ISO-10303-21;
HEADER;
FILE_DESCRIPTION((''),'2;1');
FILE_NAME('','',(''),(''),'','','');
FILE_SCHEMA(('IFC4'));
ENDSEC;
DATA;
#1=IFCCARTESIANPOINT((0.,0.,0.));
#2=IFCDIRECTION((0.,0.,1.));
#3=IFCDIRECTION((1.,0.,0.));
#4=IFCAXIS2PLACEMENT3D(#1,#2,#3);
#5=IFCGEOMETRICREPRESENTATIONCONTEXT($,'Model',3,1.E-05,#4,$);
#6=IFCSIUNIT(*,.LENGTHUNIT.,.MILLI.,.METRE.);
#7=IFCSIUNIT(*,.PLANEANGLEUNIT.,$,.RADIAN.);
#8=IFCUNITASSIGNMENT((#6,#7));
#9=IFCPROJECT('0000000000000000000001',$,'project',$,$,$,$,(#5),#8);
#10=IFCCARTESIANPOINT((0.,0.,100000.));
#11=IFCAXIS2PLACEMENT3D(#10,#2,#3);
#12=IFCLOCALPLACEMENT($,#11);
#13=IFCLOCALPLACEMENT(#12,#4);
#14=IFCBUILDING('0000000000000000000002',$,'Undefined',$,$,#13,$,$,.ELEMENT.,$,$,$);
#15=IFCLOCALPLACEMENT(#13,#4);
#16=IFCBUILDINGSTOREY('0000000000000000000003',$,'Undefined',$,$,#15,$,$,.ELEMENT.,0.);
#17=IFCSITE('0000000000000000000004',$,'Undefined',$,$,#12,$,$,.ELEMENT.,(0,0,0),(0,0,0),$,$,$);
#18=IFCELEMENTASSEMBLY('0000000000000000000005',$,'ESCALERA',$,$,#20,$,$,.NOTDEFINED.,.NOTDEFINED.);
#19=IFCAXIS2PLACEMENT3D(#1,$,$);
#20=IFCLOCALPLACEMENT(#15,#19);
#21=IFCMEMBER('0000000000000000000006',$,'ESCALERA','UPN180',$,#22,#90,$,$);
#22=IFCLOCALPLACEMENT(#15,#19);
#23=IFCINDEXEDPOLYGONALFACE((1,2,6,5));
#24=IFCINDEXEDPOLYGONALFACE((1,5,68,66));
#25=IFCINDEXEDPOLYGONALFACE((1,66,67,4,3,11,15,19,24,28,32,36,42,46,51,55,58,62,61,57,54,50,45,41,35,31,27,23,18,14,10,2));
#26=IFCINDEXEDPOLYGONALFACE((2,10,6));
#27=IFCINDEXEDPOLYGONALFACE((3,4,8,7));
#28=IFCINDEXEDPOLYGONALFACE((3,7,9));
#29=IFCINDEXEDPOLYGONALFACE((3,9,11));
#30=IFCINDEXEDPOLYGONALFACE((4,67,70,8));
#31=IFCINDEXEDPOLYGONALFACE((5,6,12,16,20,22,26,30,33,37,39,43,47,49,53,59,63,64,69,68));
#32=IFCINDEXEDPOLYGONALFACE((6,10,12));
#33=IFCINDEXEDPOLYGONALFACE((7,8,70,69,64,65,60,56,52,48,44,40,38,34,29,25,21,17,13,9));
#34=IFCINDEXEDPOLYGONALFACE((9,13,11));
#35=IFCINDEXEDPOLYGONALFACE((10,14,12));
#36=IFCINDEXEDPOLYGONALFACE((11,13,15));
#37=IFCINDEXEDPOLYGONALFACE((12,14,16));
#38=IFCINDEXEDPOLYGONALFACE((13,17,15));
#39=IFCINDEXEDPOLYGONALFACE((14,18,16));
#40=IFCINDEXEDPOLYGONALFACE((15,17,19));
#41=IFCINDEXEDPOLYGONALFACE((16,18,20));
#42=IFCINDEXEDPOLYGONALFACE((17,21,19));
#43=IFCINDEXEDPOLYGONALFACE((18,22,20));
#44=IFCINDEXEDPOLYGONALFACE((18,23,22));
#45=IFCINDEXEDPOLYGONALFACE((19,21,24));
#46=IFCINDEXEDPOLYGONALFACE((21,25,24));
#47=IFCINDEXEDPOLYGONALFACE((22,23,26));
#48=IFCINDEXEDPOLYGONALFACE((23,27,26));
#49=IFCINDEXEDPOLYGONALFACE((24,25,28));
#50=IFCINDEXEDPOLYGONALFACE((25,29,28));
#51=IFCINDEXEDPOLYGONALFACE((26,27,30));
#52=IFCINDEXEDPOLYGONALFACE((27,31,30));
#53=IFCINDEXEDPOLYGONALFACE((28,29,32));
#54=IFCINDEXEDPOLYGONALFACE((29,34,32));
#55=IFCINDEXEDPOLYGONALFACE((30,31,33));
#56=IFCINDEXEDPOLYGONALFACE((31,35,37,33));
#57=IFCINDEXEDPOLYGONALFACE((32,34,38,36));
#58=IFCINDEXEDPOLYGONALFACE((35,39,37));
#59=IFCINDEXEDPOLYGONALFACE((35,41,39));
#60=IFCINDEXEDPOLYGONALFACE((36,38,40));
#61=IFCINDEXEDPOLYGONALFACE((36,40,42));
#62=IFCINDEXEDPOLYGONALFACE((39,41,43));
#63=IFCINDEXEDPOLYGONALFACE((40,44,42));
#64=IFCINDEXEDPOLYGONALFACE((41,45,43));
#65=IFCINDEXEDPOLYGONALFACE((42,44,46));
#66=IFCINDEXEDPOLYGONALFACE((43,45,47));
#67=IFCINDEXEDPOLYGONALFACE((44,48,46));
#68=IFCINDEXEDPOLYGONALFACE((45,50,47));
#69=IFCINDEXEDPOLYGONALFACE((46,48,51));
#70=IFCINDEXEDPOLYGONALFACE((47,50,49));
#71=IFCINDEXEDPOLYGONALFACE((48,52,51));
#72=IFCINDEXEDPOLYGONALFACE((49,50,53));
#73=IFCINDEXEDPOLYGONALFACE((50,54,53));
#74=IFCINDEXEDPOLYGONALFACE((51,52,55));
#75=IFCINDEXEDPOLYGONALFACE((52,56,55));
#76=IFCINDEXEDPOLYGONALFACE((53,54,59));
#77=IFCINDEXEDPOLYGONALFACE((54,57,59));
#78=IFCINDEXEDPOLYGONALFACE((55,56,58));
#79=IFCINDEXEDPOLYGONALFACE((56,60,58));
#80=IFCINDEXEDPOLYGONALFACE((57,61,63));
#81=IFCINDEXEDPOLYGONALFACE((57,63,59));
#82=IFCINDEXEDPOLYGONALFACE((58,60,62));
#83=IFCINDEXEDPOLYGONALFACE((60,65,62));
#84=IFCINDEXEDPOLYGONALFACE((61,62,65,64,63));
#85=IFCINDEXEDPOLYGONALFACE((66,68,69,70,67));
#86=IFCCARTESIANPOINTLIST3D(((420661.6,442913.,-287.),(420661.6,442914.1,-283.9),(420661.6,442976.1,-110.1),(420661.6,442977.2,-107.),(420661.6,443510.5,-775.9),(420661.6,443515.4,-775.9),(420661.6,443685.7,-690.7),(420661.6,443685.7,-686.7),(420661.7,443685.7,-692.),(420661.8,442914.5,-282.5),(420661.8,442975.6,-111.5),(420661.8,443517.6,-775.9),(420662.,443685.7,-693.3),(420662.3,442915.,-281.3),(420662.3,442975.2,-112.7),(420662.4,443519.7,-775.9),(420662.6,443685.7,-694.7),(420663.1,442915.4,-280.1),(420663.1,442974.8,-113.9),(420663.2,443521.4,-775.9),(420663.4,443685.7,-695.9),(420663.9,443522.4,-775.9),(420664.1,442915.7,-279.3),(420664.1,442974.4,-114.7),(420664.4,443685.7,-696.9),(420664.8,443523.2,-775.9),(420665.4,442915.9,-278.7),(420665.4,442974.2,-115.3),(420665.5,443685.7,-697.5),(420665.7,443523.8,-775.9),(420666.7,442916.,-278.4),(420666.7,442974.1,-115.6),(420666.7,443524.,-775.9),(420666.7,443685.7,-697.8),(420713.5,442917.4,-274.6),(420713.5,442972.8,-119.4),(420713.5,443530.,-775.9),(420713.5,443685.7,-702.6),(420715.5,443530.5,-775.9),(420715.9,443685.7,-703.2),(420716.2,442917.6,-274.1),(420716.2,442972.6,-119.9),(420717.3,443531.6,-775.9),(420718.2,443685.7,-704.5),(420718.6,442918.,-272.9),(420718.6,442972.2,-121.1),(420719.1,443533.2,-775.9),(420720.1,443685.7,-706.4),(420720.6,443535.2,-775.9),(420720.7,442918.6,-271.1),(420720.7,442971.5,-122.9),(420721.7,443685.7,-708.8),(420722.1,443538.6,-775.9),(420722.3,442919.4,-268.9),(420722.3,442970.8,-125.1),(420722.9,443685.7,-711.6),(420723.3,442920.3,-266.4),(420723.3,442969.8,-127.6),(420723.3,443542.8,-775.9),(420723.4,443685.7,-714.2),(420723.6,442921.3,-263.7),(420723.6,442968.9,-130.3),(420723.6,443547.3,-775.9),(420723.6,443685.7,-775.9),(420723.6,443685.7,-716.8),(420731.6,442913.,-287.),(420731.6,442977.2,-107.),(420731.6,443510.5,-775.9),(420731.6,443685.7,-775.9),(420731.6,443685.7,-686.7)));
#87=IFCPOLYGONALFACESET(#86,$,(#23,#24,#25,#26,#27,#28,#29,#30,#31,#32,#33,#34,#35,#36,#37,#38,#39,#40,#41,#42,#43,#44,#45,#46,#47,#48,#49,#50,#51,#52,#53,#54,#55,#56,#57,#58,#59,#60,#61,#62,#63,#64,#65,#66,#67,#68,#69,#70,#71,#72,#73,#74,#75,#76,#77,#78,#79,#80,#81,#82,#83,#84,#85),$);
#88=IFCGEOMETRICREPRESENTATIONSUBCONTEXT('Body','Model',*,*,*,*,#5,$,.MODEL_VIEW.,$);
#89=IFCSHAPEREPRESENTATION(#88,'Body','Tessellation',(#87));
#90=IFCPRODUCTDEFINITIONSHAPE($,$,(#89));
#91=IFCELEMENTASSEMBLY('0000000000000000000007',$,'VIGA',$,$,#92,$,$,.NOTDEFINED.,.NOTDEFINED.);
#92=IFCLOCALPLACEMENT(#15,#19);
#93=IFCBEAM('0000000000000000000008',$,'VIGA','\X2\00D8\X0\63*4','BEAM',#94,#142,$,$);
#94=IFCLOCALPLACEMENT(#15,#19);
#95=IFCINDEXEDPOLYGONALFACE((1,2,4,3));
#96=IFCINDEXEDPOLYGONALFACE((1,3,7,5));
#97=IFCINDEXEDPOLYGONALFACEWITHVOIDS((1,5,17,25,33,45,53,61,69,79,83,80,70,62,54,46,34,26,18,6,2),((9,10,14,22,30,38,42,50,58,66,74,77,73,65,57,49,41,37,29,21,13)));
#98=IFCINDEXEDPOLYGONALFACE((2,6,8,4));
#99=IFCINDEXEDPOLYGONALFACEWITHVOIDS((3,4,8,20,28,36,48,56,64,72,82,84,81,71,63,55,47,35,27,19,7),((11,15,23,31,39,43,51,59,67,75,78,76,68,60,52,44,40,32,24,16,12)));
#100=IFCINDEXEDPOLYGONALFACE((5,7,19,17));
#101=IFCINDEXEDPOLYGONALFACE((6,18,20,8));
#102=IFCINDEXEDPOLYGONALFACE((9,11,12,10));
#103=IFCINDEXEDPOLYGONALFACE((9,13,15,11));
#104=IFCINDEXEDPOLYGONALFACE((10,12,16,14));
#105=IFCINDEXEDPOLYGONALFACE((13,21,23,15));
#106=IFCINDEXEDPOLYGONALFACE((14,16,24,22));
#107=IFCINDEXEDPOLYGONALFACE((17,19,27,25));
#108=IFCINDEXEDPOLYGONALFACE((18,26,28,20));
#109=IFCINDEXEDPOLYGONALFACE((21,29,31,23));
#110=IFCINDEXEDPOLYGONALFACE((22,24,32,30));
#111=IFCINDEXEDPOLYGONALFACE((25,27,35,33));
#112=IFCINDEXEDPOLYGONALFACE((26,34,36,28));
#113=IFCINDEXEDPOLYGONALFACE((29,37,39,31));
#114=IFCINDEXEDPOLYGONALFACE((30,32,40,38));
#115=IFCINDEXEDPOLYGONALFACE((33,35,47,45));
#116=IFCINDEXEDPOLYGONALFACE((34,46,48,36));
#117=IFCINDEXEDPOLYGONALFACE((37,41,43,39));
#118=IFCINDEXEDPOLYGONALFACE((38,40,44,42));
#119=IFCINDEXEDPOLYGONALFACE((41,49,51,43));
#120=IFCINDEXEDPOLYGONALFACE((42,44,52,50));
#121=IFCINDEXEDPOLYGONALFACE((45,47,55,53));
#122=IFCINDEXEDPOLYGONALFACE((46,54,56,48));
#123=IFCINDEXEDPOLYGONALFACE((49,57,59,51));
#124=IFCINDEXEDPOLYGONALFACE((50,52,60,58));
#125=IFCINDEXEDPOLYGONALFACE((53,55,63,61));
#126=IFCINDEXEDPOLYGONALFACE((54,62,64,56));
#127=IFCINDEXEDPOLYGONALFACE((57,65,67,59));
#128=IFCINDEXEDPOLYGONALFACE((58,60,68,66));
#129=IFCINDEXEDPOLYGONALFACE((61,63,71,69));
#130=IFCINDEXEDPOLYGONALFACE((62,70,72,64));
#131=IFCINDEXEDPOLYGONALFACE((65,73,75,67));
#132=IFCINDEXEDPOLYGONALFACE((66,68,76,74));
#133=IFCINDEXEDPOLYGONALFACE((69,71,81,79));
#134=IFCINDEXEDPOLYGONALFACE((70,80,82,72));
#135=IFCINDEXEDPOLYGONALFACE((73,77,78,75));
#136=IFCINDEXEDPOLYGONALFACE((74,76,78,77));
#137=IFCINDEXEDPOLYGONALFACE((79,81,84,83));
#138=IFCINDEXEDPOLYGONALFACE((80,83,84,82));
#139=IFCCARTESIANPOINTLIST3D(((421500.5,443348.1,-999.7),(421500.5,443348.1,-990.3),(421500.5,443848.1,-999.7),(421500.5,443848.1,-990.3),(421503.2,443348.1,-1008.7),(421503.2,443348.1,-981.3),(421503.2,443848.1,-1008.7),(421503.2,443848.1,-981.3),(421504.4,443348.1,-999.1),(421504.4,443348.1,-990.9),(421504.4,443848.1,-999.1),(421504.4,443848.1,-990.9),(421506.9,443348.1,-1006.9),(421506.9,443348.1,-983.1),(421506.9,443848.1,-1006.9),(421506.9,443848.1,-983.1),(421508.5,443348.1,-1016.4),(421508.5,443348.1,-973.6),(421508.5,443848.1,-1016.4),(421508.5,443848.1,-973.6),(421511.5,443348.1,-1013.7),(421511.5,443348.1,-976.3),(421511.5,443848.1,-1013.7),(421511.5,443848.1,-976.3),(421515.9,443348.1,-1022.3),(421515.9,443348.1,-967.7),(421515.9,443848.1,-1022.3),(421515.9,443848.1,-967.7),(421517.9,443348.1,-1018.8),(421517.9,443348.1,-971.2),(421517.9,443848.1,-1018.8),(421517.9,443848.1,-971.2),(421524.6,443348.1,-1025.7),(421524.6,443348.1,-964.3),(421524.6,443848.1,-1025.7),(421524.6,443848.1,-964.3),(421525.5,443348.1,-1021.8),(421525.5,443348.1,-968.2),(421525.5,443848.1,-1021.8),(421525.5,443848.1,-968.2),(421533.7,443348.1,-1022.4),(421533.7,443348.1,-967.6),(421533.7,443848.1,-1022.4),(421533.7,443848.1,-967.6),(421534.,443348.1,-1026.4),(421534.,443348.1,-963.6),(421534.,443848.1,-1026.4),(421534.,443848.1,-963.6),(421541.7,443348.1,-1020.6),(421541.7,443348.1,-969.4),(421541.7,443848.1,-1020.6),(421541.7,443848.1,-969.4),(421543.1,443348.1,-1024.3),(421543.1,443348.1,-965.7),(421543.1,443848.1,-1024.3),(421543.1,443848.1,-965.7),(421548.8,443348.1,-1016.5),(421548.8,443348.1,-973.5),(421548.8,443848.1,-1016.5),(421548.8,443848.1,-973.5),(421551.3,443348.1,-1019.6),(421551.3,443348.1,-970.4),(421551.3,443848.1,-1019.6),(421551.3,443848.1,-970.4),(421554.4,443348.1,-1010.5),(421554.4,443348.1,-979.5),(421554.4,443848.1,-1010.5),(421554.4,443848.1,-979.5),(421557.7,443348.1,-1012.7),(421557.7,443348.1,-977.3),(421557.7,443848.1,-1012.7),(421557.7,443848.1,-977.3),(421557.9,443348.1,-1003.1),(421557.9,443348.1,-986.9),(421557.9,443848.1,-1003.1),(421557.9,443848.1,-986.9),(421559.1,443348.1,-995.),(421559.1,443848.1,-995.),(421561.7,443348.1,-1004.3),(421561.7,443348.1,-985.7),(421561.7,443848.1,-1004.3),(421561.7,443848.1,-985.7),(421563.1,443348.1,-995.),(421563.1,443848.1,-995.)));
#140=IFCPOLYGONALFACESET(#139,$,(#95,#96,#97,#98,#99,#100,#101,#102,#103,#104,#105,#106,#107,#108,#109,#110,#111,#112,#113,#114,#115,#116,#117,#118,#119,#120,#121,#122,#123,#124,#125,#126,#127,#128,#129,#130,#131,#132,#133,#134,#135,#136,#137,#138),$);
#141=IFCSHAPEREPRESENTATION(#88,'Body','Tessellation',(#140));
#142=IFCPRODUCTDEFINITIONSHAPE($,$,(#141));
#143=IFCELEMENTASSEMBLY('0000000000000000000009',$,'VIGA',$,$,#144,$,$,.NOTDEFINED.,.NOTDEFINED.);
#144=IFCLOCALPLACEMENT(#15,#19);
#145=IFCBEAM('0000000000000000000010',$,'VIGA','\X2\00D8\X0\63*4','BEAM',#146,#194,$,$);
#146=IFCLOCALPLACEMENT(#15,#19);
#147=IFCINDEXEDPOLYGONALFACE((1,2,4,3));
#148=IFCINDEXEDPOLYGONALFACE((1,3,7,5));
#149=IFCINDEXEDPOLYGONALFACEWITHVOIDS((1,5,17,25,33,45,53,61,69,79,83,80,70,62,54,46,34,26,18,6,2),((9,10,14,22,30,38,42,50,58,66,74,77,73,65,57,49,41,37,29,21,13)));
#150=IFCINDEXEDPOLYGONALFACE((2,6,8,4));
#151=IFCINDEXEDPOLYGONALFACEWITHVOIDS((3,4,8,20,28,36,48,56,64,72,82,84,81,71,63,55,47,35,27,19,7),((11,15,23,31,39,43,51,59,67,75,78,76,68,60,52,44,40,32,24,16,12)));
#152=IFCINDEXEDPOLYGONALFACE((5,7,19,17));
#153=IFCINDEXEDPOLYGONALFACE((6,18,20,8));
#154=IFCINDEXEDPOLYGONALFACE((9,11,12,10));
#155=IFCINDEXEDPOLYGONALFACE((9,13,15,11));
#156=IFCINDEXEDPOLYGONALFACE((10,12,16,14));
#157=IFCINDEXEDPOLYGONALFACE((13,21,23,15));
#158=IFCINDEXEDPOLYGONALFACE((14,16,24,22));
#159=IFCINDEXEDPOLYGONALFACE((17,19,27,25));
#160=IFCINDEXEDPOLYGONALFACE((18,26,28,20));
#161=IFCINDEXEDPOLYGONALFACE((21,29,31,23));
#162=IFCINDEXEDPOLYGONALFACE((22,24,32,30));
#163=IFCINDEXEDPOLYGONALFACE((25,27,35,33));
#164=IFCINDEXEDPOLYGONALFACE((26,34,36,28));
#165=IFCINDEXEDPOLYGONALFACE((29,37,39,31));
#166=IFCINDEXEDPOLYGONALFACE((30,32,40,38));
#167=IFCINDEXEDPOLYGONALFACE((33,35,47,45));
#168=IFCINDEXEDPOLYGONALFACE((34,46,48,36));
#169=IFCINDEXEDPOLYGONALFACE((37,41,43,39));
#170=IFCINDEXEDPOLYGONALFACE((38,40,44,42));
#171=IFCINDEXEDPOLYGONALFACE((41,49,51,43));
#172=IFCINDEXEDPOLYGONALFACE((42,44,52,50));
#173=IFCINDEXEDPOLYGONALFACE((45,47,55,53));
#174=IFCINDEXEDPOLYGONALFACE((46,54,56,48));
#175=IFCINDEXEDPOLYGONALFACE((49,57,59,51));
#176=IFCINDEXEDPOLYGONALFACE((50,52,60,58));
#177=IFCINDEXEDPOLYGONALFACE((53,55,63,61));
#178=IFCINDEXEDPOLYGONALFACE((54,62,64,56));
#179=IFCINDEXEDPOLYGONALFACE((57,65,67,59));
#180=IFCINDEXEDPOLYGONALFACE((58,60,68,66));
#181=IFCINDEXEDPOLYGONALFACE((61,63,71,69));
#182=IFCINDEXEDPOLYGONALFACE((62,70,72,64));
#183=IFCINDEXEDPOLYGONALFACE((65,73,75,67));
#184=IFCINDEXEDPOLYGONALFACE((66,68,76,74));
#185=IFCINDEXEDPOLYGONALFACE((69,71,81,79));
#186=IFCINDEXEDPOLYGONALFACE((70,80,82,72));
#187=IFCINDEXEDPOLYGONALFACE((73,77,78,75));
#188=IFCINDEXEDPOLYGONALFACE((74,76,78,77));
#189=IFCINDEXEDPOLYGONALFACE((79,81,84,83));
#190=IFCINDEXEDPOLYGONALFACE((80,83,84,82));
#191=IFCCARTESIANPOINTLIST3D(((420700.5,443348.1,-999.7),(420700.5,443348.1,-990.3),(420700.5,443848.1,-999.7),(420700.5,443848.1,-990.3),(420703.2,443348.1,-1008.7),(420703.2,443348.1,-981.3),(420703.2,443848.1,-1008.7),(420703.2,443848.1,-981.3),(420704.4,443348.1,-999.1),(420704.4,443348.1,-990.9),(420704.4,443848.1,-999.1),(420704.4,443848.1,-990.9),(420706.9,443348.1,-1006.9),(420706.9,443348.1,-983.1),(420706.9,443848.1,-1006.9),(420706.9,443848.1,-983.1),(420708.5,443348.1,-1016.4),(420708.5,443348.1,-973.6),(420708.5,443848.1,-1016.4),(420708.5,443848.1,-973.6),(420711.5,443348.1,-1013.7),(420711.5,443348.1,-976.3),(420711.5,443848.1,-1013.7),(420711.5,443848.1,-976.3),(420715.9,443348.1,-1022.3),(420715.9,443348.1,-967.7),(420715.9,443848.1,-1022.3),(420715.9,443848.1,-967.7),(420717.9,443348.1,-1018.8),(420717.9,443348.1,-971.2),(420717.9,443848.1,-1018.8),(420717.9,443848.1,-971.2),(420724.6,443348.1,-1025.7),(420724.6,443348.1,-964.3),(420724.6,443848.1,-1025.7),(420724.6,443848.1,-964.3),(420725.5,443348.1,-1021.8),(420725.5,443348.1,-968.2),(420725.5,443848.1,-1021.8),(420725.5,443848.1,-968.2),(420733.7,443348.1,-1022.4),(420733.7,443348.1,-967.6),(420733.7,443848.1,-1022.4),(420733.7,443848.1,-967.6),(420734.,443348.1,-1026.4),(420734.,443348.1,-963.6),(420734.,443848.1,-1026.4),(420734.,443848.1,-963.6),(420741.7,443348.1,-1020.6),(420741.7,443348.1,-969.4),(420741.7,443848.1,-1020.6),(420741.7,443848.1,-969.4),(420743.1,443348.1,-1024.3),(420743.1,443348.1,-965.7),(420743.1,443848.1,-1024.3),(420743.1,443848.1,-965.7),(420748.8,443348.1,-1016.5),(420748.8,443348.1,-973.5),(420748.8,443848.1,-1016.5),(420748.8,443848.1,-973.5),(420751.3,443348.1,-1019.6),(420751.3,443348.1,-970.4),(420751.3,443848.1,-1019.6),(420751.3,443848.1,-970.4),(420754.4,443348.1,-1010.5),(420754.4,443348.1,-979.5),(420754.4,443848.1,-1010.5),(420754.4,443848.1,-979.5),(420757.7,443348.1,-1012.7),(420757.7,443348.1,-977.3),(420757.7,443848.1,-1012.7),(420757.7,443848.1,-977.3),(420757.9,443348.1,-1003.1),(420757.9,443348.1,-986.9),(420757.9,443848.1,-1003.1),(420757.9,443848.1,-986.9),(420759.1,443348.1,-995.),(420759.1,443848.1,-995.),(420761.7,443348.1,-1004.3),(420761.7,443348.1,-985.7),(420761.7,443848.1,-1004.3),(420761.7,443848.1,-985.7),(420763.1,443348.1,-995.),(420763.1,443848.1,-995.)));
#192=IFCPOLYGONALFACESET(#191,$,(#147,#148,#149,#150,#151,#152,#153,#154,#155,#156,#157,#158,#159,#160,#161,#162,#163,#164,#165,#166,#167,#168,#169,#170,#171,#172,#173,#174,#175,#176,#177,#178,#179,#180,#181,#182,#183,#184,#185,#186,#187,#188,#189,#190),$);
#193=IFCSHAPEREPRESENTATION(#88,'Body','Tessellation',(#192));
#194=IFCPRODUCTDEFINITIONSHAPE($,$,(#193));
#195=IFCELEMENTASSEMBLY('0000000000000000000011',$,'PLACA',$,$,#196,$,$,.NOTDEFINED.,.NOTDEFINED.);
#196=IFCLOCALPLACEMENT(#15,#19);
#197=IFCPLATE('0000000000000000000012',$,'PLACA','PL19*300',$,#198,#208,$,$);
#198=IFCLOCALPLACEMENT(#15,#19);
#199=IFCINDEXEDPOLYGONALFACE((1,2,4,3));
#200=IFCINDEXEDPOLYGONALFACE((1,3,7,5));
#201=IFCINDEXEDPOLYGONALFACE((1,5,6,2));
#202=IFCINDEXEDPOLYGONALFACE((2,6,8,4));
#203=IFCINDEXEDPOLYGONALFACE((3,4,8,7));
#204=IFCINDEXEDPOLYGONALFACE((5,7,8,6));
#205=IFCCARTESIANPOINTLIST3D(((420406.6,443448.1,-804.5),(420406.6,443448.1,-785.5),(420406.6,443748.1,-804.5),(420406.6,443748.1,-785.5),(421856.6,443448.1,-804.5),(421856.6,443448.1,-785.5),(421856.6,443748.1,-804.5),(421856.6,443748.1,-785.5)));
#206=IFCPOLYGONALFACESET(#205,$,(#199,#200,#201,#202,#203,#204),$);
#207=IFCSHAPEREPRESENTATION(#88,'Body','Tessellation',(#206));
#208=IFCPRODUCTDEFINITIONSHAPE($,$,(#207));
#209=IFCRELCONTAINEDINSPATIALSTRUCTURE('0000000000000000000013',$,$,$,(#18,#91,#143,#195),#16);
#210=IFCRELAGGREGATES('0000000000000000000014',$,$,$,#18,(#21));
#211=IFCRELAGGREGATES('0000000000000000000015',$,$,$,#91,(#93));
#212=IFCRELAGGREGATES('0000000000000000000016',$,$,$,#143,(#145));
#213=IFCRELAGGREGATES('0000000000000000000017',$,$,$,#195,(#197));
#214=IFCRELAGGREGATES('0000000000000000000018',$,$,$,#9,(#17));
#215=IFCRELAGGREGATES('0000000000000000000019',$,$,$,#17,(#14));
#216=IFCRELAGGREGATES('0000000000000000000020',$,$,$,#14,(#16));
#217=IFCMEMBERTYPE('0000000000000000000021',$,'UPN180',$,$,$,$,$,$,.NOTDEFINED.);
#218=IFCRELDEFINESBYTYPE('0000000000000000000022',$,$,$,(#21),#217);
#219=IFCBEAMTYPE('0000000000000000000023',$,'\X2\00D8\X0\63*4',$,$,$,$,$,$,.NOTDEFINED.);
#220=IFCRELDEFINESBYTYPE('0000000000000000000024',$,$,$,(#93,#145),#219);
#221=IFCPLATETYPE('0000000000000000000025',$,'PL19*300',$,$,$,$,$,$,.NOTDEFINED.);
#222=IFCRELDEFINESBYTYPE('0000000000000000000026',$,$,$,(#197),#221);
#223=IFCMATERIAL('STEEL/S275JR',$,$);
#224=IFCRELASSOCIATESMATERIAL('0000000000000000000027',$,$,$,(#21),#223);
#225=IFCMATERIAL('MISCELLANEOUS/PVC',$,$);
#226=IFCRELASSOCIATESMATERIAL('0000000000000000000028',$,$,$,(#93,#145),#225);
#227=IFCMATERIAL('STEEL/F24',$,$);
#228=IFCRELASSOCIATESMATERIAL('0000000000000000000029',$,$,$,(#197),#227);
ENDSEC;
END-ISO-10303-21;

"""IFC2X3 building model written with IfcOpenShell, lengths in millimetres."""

from ifc_helpers import new_model, si_unit, frame, origin_with_axes, origin_2d_with_axis, place, context, subcontext, project, spatial, polyline, hollow_circle, u_section, outline, extrude, clip, halfspace, material, type_object, element, aggregate, save


model = new_model("IFC2X3")

# Units and contexts
model_context = context("Model", 3, precision=1e-05, world=origin_with_axes())
body_context = subcontext(model_context, "Body", "Model", "MODEL_VIEW")
ifc_project = project(units=[si_unit("LENGTHUNIT", "METRE", prefix="MILLI"), si_unit("PLANEANGLEUNIT", "RADIAN")], contexts=[model_context])

# Site, building, storey
site_placement = place(None, frame((0.0, 0.0, 100000.0), z_axis=(0.0, 0.0, 1.0), x_axis=(1.0, 0.0, 0.0)))
site = spatial("IfcSite", under=ifc_project, at=site_placement, Name="Undefined", CompositionType="ELEMENT", RefLatitude=(0, 0, 0), RefLongitude=(0, 0, 0))
building_placement = place(site_placement, origin_with_axes())
building = spatial("IfcBuilding", under=site, at=building_placement, Name="Undefined", CompositionType="ELEMENT")
storey_placement = place(building_placement, origin_with_axes())
storey = spatial("IfcBuildingStorey", under=building, at=storey_placement, Name="Undefined", CompositionType="ELEMENT", Elevation=0.0)

# Element assembly
ifc_material_1 = material(Name="STEEL/F24")
ifc_material_2 = material(Name="STEEL/S275JR")
assembly_1_placement = place(storey_placement, origin_with_axes())
assembly_1 = element("IfcElementAssembly", 1, at=assembly_1_placement, inside=storey, Name="ESCALERA", AssemblyPlace="NOTDEFINED", PredefinedType="NOTDEFINED")

# Member
member_type = type_object("IfcMemberType", Name="UPN180", PredefinedType="NOTDEFINED")
member_placement = place(assembly_1_placement, frame((420696.6, 443541.1, -684.7), z_axis=(-0.000001, 0.633238, 0.773957), x_axis=(0.000001, -0.773957, 0.633238)))
member = element("IfcMember", 2, at=member_placement, type_object=member_type, material=ifc_material_2, Name="ESCALERA", Description="UPN180", context=body_context, shape_type="Clipping", body=[
    clip(clip(clip(extrude(u_section(Depth=180.0, FlangeWidth=70.0, WebThickness=8.0, FlangeThickness=11.0, FilletRadius=11.0, EdgeRadius=5.5, FlangeSlope=0.07983, at=origin_2d_with_axis()), frame((878.7, 0.0, 0.0), z_axis=(-1.0, 0.0, 0.0), x_axis=(0.0, -1.0, 0.0)), (0.0, 0.0, 1.0), 1131.3), halfspace(frame((-260.5, 35.0, -90.0), z_axis=(-0.773957, 0.0, 0.633238), x_axis=(0.633238, 0.0, 0.773957)), False)), halfspace(frame((802.2, -35.0, 90.0), z_axis=(-0.941795, 0.0, 0.336186), x_axis=(0.0, -1.0, 0.0)), True)), halfspace(frame((-92.3, -1035.0, -42.3), z_axis=(0.633238, 0.0, 0.773957), x_axis=(-0.773957, 0.0, 0.633238)), True)),
])
aggregate(assembly_1, [member])

# Element assemblies, beams
assembly_2_placement = place(storey_placement, origin_with_axes())
assembly_2 = element("IfcElementAssembly", 3, at=assembly_2_placement, inside=storey, Name="VIGA", AssemblyPlace="NOTDEFINED", PredefinedType="NOTDEFINED")
ifc_material_3 = material(Name="MISCELLANEOUS/PVC")
beam_type_1 = type_object("IfcBeamType", Name="Ø63*4", PredefinedType="NOTDEFINED")
beam_1_placement = place(assembly_2_placement, frame((421531.6, 443348.1, -995.0), z_axis=(0.0, 0.0, 1.0), x_axis=(0.0, 1.0, 0.0)))
beam_1 = element("IfcBeam", 4, at=beam_1_placement, type_object=beam_type_1, material=ifc_material_3, Name="VIGA", Description="Ø63*4", ObjectType="BEAM", context=body_context, shape_type="SweptSolid", body=[
    extrude(hollow_circle(Radius=31.5, WallThickness=4.0, at=origin_2d_with_axis()), frame((500.0, 0.0, 0.0), z_axis=(-1.0, 0.0, 0.0), x_axis=(0.0, -1.0, 0.0)), (0.0, 0.0, 1.0), 500.0),
])
aggregate(assembly_2, [beam_1])
assembly_3_placement = place(storey_placement, origin_with_axes())
assembly_3 = element("IfcElementAssembly", 5, at=assembly_3_placement, inside=storey, Name="VIGA", AssemblyPlace="NOTDEFINED", PredefinedType="NOTDEFINED")
beam_2_placement = place(assembly_3_placement, frame((420731.6, 443348.1, -995.0), z_axis=(0.0, 0.0, 1.0), x_axis=(0.0, 1.0, 0.0)))
beam_2 = element("IfcBeam", 6, at=beam_2_placement, type_object=beam_type_1, material=ifc_material_3, Name="VIGA", Description="Ø63*4", ObjectType="BEAM", context=body_context, shape_type="SweptSolid", body=[
    extrude(hollow_circle(Radius=31.5, WallThickness=4.0, at=origin_2d_with_axis()), frame((500.0, 0.0, 0.0), z_axis=(-1.0, 0.0, 0.0), x_axis=(0.0, -1.0, 0.0)), (0.0, 0.0, 1.0), 500.0),
])
aggregate(assembly_3, [beam_2])

# Element assembly, plate
assembly_4_placement = place(storey_placement, origin_with_axes())
assembly_4 = element("IfcElementAssembly", 7, at=assembly_4_placement, inside=storey, Name="PLACA", AssemblyPlace="NOTDEFINED", PredefinedType="NOTDEFINED")
plate_type = type_object("IfcPlateType", Name="PL19*300", PredefinedType="NOTDEFINED")
plate_placement = place(assembly_4_placement, frame((421856.6, 443448.1, -795.0), z_axis=(0.0, 0.0, -1.0), x_axis=(-1.0, 0.0, 0.0)))
plate = element("IfcPlate", 8, at=plate_placement, type_object=plate_type, material=ifc_material_1, Name="PLACA", Description="PL19*300", context=body_context, shape_type="SweptSolid", body=[
    extrude(outline(polyline([(0.0, 0.0), (1450.0, 0.0), (1450.0, 300.0), (0.0, 300.0), (0.0, 0.0)])), frame((0.0, 0.0, -9.5), z_axis=(0.0, 0.0, 1.0), x_axis=(1.0, 0.0, 0.0)), (0.0, 0.0, 1.0), 19.0),
])
aggregate(assembly_4, [plate])

save(model, "model.ifc")
